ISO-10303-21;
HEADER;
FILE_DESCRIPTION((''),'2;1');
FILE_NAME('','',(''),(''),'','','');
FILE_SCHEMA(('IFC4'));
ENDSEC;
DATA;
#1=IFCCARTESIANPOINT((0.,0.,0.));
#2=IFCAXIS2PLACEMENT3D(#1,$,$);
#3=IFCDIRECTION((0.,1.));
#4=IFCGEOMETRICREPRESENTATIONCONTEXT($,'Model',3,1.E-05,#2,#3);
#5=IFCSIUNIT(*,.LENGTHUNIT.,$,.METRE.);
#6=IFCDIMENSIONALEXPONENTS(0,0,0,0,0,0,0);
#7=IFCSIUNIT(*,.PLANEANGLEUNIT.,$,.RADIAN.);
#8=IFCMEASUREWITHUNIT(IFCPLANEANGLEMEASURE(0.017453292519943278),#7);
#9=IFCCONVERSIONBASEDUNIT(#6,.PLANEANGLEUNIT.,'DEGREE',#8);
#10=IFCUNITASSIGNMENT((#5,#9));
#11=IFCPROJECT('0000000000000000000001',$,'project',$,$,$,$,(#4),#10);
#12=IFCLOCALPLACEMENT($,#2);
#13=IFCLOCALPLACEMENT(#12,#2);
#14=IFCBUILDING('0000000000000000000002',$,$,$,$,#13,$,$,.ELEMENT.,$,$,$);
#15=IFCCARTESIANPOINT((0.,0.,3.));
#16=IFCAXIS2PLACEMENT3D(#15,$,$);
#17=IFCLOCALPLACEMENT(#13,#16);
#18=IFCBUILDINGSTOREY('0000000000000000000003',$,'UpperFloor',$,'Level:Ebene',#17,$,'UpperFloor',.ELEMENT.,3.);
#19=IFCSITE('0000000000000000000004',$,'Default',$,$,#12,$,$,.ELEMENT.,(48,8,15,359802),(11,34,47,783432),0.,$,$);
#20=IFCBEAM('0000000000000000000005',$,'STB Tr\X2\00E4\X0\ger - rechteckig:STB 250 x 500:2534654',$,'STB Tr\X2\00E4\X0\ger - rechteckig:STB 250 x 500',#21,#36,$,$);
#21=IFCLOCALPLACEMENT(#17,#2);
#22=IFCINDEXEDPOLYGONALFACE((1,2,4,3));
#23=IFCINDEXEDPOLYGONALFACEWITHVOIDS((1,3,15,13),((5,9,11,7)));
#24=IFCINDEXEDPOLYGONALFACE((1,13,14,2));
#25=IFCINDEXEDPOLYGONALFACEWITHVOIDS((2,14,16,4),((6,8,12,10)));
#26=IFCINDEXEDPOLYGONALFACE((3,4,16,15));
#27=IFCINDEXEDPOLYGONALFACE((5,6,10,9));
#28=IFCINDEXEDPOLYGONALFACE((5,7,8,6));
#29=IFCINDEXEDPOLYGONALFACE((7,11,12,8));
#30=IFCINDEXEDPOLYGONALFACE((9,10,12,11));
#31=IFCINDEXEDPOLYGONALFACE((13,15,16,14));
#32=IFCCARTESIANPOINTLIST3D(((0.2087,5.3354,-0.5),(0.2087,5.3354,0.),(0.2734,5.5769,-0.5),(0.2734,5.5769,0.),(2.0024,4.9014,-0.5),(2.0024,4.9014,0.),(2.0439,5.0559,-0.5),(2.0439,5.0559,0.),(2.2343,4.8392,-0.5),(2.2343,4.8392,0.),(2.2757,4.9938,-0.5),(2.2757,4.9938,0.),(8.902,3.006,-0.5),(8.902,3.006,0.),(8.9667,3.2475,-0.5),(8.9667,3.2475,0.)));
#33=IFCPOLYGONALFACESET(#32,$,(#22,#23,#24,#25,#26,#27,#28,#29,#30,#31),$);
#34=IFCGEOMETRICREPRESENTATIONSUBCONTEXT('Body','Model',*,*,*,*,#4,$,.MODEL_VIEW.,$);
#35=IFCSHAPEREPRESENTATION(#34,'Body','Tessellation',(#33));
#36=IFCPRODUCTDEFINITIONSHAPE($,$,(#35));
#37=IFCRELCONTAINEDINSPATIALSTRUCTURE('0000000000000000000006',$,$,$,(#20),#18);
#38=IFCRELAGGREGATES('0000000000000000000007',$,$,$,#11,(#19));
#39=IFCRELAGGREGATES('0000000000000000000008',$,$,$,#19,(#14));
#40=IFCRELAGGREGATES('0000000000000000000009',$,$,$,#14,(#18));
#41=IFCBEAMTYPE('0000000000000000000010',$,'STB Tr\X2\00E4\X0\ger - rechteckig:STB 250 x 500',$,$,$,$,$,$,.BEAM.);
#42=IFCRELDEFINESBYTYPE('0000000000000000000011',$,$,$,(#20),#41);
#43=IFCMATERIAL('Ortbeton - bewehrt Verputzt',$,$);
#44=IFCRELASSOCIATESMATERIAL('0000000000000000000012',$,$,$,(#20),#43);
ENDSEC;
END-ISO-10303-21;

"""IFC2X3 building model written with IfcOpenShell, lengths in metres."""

from ifc_helpers import new_model, entity, si_unit, converted_unit, direction, frame, frame_2d, origin, place, context, subcontext, project, spatial, rectangle, extrude, boolean, material, type_object, element, save


model = new_model("IFC2X3")

# Units and contexts
model_context = context("Model", 3, precision=1e-05, world=origin(), true_north=direction((0.0, 1.0)))
body_context = subcontext(model_context, "Body", "Model", "MODEL_VIEW")
ifc_project = project(units=[si_unit("LENGTHUNIT", "METRE"), converted_unit("PLANEANGLEUNIT", "DEGREE", entity("IfcPlaneAngleMeasure", 0.017453292519943278), si_unit("PLANEANGLEUNIT", "RADIAN"), dimensions=[0, 0, 0, 0, 0, 0, 0])], contexts=[model_context])

# Site, building, storey
site_placement = place(None, origin())
site = spatial("IfcSite", under=ifc_project, at=site_placement, Name="Default", CompositionType="ELEMENT", RefLatitude=(48, 8, 15, 359802), RefLongitude=(11, 34, 47, 783432), RefElevation=0.0)
building_placement = place(site_placement, origin())
building = spatial("IfcBuilding", under=site, at=building_placement, CompositionType="ELEMENT")
storey_placement = place(building_placement, frame((0.0, 0.0, 3.0)))
storey = spatial("IfcBuildingStorey", under=building, at=storey_placement, Name="UpperFloor", ObjectType="Level:Ebene", LongName="UpperFloor", CompositionType="ELEMENT", Elevation=3.0)

# Beam
ifc_material = material(Name="Ortbeton - bewehrt Verputzt")
beam_type = type_object("IfcBeamType", Name="STB Träger - rechteckig:STB 250 x 500", PredefinedType="BEAM")
beam_placement = place(storey_placement, frame((0.241, 5.4561, 0.0), z_axis=(0.0, 0.0, 1.0), x_axis=(0.965926, -0.258819, 0.0)))
element("IfcBeam", 1, at=beam_placement, inside=storey, type_object=beam_type, material=ifc_material, Name="STB Träger - rechteckig:STB 250 x 500:2534654", ObjectType="STB Träger - rechteckig:STB 250 x 500", context=body_context, shape_type="CSG", body=[
    boolean("DIFFERENCE", extrude(rectangle(XDim=0.5, YDim=0.25, at=frame_2d((0.0, 0.0), x_axis=(1.0, 0.0))), frame((0.0, 0.0, -0.25), z_axis=(1.0, 0.0, 0.0), x_axis=(0.0, 0.0, -1.0)), (0.0, 0.0, 1.0), 9.0), extrude(rectangle(XDim=0.16, YDim=0.24, at=frame_2d((0.0, 0.0), x_axis=(1.0, 0.0))), frame((1.965, 0.0, -0.5), z_axis=(0.0, 0.0, 1.0), x_axis=(0.0, 1.0, 0.0)), (0.0, 0.0, 1.0), 0.5)),
])

save(model, "model.ifc")
